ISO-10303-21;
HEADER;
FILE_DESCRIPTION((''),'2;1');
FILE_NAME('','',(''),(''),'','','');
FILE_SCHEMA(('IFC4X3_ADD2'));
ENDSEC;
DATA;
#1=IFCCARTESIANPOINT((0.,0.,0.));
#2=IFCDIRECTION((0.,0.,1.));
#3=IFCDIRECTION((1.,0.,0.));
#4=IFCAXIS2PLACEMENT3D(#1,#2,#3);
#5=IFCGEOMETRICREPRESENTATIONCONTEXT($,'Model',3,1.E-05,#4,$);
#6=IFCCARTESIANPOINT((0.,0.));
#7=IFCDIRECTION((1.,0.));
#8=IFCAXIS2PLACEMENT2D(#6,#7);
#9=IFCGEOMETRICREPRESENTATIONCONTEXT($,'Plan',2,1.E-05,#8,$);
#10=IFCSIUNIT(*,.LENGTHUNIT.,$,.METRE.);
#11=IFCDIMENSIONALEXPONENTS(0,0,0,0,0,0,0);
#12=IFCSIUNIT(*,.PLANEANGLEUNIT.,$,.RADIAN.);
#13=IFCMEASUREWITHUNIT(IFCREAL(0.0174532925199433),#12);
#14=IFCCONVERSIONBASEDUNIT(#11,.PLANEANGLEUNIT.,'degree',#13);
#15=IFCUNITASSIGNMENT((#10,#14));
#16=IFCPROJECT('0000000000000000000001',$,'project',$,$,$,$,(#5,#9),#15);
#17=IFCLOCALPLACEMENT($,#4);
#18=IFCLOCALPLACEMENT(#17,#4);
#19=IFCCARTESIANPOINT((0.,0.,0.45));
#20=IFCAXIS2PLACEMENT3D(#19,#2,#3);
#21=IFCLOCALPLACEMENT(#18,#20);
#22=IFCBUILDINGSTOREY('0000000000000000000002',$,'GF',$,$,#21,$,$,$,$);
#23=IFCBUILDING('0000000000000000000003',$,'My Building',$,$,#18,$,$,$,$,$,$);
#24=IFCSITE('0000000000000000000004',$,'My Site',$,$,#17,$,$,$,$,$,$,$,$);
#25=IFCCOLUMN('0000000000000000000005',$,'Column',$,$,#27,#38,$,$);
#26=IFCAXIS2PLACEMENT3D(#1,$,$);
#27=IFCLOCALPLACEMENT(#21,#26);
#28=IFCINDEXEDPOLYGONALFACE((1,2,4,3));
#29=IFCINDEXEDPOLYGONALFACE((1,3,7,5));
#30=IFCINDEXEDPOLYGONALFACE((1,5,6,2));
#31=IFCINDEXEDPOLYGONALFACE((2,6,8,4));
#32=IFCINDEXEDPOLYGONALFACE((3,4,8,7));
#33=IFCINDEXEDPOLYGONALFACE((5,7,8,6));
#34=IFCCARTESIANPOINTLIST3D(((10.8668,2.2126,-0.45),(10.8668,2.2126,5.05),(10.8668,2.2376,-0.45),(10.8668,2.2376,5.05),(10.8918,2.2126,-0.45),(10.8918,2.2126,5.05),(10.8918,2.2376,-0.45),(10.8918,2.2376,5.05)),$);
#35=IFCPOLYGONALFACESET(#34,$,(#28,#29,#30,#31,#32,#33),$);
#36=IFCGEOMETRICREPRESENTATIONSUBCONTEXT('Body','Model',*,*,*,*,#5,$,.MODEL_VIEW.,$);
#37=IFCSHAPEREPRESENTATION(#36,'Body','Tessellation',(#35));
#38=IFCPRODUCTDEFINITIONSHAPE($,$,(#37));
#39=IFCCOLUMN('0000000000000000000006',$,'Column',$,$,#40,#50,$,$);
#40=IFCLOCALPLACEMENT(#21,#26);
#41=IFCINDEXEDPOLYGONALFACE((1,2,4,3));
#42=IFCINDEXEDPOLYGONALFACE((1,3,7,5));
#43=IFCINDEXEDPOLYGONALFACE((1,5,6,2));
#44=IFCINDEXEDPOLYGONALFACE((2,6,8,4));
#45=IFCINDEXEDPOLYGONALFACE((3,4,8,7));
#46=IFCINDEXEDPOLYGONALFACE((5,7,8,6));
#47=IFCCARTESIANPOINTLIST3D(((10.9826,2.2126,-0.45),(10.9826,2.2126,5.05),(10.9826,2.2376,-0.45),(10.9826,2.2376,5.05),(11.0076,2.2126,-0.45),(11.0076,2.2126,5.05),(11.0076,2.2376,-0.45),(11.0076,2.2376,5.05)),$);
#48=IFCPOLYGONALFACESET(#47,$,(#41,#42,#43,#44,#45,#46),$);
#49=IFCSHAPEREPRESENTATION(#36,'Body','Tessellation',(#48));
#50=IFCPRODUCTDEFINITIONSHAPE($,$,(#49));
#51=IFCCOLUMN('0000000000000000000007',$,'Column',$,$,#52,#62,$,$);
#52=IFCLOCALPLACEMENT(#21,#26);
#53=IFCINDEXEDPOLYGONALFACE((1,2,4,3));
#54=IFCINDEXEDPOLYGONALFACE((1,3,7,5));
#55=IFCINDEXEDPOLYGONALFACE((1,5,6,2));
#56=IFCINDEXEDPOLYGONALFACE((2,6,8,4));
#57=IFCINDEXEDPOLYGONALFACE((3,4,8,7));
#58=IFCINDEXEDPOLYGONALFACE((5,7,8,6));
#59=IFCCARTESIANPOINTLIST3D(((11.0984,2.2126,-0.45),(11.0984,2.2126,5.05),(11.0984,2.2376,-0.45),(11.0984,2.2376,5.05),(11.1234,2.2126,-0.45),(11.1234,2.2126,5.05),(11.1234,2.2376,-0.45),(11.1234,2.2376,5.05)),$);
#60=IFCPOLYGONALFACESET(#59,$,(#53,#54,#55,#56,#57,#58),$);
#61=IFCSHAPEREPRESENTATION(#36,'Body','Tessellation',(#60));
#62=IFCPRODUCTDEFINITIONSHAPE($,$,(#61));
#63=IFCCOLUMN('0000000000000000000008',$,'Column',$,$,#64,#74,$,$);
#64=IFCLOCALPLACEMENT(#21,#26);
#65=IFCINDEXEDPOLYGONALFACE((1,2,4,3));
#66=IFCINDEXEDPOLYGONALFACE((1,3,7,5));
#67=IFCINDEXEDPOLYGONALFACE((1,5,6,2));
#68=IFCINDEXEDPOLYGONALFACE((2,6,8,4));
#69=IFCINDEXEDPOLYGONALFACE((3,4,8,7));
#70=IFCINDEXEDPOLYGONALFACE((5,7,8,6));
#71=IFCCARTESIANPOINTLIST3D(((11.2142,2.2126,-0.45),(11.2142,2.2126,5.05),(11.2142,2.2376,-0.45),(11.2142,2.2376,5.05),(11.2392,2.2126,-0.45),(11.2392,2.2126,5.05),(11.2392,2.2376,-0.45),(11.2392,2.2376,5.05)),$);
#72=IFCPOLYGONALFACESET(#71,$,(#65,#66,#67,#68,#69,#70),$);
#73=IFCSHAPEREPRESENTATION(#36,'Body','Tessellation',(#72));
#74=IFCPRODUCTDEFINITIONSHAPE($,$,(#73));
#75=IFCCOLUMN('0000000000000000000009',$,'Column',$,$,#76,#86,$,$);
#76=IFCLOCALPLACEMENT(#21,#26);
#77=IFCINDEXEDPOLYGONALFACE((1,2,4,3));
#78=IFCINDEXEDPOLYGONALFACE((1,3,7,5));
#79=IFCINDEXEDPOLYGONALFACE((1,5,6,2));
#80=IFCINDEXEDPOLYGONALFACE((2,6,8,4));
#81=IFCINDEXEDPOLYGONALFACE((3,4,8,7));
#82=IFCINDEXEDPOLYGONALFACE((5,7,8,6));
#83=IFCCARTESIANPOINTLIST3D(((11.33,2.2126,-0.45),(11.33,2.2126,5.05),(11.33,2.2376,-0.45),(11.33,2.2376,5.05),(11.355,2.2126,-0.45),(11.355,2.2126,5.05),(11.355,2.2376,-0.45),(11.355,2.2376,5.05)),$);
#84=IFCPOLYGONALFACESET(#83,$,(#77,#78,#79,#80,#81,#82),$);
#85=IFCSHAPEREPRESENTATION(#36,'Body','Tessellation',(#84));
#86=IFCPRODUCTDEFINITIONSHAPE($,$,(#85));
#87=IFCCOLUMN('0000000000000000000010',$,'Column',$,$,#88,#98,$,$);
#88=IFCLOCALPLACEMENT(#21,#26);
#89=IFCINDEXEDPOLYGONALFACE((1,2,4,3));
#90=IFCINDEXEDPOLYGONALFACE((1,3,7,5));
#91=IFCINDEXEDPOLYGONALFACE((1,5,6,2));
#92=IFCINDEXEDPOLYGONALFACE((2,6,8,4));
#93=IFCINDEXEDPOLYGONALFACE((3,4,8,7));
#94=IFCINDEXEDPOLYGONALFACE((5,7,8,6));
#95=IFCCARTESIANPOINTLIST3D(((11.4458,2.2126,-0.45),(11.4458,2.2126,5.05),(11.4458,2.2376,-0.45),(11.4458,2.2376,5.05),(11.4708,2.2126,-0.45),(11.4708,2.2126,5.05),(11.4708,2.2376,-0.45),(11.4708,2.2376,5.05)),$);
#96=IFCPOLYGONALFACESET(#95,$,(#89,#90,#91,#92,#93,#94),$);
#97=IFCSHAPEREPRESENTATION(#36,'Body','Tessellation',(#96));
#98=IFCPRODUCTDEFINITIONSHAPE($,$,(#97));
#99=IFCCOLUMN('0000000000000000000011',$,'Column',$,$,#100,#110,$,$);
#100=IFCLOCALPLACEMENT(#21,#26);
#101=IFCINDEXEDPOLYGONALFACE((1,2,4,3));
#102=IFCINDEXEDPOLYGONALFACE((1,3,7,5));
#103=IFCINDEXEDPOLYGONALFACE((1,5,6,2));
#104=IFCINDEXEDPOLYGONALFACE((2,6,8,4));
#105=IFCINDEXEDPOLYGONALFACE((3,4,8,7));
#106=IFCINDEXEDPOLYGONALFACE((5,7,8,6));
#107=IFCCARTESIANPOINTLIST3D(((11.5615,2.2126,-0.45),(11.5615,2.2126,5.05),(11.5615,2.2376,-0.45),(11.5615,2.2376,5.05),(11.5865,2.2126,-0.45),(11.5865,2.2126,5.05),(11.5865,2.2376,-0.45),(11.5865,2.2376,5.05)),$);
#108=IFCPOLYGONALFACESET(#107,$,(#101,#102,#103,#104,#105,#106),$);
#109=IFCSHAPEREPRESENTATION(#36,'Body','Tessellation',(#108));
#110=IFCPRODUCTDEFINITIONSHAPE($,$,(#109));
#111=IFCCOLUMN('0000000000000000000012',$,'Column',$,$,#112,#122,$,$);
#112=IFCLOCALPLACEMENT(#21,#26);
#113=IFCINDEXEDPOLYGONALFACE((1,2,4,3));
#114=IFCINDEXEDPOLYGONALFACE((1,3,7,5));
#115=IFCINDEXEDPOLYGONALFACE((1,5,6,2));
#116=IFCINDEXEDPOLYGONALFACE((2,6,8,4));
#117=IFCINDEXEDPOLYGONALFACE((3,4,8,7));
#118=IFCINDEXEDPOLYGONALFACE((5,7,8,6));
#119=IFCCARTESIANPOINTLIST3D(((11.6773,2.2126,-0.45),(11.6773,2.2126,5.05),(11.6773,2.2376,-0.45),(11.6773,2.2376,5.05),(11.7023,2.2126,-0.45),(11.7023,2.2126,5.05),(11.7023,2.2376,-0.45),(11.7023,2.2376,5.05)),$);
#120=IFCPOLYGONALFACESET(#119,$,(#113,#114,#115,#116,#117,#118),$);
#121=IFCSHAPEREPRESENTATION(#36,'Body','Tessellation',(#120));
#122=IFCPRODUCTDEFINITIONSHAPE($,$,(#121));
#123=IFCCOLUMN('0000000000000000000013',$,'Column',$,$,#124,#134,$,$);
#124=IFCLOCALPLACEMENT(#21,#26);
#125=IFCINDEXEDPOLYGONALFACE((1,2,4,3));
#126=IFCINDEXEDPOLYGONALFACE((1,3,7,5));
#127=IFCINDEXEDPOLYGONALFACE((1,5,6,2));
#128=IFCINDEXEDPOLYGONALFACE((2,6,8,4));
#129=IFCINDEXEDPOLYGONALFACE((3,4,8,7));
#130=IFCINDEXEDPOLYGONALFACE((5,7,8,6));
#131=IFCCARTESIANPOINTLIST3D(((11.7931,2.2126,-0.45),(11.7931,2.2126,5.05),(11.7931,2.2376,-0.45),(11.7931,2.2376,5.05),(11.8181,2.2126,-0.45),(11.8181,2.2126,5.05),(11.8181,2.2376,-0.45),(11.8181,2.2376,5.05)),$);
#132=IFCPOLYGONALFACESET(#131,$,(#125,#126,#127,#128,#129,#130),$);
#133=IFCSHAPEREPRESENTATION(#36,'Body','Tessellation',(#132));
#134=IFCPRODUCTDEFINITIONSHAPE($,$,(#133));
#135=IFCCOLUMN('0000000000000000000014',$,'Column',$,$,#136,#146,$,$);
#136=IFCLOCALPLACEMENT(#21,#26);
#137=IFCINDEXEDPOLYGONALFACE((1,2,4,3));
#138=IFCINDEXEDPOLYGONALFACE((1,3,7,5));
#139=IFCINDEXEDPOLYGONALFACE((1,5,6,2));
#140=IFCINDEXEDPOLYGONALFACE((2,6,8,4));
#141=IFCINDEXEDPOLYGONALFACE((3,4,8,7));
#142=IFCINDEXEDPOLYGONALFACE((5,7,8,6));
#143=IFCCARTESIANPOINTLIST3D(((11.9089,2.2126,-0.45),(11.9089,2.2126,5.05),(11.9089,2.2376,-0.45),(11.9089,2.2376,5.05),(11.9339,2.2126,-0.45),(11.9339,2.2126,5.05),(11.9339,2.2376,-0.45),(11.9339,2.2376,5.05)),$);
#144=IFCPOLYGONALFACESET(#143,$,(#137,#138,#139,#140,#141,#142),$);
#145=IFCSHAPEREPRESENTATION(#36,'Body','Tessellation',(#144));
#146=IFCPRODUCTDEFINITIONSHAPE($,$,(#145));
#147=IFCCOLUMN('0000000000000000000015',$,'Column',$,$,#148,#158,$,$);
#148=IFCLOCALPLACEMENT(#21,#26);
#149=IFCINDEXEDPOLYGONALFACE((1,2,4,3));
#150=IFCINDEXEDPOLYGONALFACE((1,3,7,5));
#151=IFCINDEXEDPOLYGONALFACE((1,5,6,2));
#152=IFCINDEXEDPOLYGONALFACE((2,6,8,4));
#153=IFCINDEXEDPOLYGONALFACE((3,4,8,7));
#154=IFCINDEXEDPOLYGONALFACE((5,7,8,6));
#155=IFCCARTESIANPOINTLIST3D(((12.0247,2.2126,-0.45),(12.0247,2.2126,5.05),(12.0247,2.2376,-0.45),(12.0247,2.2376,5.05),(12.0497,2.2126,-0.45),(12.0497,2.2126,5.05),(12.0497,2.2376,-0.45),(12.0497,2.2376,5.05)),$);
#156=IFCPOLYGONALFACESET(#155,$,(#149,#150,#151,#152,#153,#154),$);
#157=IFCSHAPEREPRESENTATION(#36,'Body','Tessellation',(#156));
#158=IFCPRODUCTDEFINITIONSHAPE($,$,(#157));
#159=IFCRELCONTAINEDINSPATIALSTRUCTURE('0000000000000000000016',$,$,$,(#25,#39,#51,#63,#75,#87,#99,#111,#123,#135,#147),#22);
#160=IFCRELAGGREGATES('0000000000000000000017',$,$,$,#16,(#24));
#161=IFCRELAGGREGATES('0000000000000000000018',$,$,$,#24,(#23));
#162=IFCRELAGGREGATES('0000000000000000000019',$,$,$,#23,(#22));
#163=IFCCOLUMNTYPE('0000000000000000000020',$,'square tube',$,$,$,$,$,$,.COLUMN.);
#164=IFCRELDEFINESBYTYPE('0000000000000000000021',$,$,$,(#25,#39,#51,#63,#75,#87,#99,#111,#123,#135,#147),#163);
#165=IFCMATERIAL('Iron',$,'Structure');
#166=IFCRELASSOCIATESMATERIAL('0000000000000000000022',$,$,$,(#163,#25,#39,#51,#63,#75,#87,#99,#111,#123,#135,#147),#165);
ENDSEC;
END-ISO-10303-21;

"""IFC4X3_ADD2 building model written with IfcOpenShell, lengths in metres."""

from ifc_helpers import new_model, entity, si_unit, converted_unit, frame, origin_with_axes, origin_2d_with_axis, place, context, subcontext, project, spatial, indexed_curve, outline, extrude, material, material_profile, profile_set, profile_usage, type_object, element, save


model = new_model("IFC4X3_ADD2")

# Units and contexts
model_context = context("Model", 3, precision=1e-05, world=origin_with_axes())
plan_context = context("Plan", 2, precision=1e-05, world=origin_2d_with_axis())
body_context_1 = subcontext(model_context, "Body", "Model", "MODEL_VIEW")
ifc_project = project(units=[si_unit("LENGTHUNIT", "METRE"), converted_unit("PLANEANGLEUNIT", "degree", entity("IfcReal", 0.0174532925199433), si_unit("PLANEANGLEUNIT", "RADIAN"), dimensions=[0, 0, 0, 0, 0, 0, 0])], contexts=[model_context, plan_context])

# Site, building, storey
site_placement = place(None, origin_with_axes())
site = spatial("IfcSite", under=ifc_project, at=site_placement, Name="My Site")
building_placement = place(site_placement, origin_with_axes())
building = spatial("IfcBuilding", under=site, at=building_placement, Name="My Building")
storey_placement = place(building_placement, frame((0.0, 0.0, 0.45), z_axis=(0.0, 0.0, 1.0), x_axis=(1.0, 0.0, 0.0)))
storey = spatial("IfcBuildingStorey", under=building, at=storey_placement, Name="GF")

# Columns
ifc_material_1 = material(Name="Iron", Category="Structure")
ifc_material_profile = material_profile(ifc_material_1, outline(indexed_curve([(-0.0125, -0.0125), (0.0125, -0.0125), (0.0125, 0.0125), (-0.0125, 0.0125), (-0.0125, -0.0125)])))
ifc_profile_set = profile_set([ifc_material_profile])
column_type = type_object("IfcColumnType", Name="square tube", PredefinedType="COLUMN", material=ifc_profile_set)
ifc_profile_usage_1 = profile_usage(ifc_profile_set, cardinal=5)
column_1_placement = place(storey_placement, frame((10.8793, 2.2251, -0.45), z_axis=(0.0, 0.0, 1.0), x_axis=(1.0, 0.0, 0.0)))
element("IfcColumn", 1, at=column_1_placement, inside=storey, type_object=column_type, material=ifc_profile_usage_1, Name="Column", context=body_context_1, shape_type="SweptSolid", body=[
    extrude(outline(indexed_curve([(-0.0125, -0.0125), (0.0125, -0.0125), (0.0125, 0.0125), (-0.0125, 0.0125), (-0.0125, -0.0125)])), origin_with_axes(), (0.0, 0.0, 1.0), 5.5),
])
ifc_profile_usage_2 = profile_usage(ifc_profile_set, cardinal=5)
column_2_placement = place(storey_placement, frame((10.9951, 2.2251, -0.45), z_axis=(0.0, 0.0, 1.0), x_axis=(1.0, 0.0, 0.0)))
element("IfcColumn", 2, at=column_2_placement, inside=storey, type_object=column_type, material=ifc_profile_usage_2, Name="Column", context=body_context_1, shape_type="SweptSolid", body=[
    extrude(outline(indexed_curve([(-0.0125, -0.0125), (0.0125, -0.0125), (0.0125, 0.0125), (-0.0125, 0.0125), (-0.0125, -0.0125)])), origin_with_axes(), (0.0, 0.0, 1.0), 5.5),
])
ifc_profile_usage_3 = profile_usage(ifc_profile_set, cardinal=5)
column_3_placement = place(storey_placement, frame((11.1109, 2.2251, -0.45), z_axis=(0.0, 0.0, 1.0), x_axis=(1.0, 0.0, 0.0)))
element("IfcColumn", 3, at=column_3_placement, inside=storey, type_object=column_type, material=ifc_profile_usage_3, Name="Column", context=body_context_1, shape_type="SweptSolid", body=[
    extrude(outline(indexed_curve([(-0.0125, -0.0125), (0.0125, -0.0125), (0.0125, 0.0125), (-0.0125, 0.0125), (-0.0125, -0.0125)])), origin_with_axes(), (0.0, 0.0, 1.0), 5.5),
])
ifc_profile_usage_4 = profile_usage(ifc_profile_set, cardinal=5)
column_4_placement = place(storey_placement, frame((11.2267, 2.2251, -0.45), z_axis=(0.0, 0.0, 1.0), x_axis=(1.0, 0.0, 0.0)))
element("IfcColumn", 4, at=column_4_placement, inside=storey, type_object=column_type, material=ifc_profile_usage_4, Name="Column", context=body_context_1, shape_type="SweptSolid", body=[
    extrude(outline(indexed_curve([(-0.0125, -0.0125), (0.0125, -0.0125), (0.0125, 0.0125), (-0.0125, 0.0125), (-0.0125, -0.0125)])), origin_with_axes(), (0.0, 0.0, 1.0), 5.5),
])
ifc_profile_usage_5 = profile_usage(ifc_profile_set, cardinal=5)
column_5_placement = place(storey_placement, frame((11.3425, 2.2251, -0.45), z_axis=(0.0, 0.0, 1.0), x_axis=(1.0, 0.0, 0.0)))
element("IfcColumn", 5, at=column_5_placement, inside=storey, type_object=column_type, material=ifc_profile_usage_5, Name="Column", context=body_context_1, shape_type="SweptSolid", body=[
    extrude(outline(indexed_curve([(-0.0125, -0.0125), (0.0125, -0.0125), (0.0125, 0.0125), (-0.0125, 0.0125), (-0.0125, -0.0125)])), origin_with_axes(), (0.0, 0.0, 1.0), 5.5),
])
ifc_profile_usage_6 = profile_usage(ifc_profile_set, cardinal=5)
column_6_placement = place(storey_placement, frame((11.4583, 2.2251, -0.45), z_axis=(0.0, 0.0, 1.0), x_axis=(1.0, 0.0, 0.0)))
element("IfcColumn", 6, at=column_6_placement, inside=storey, type_object=column_type, material=ifc_profile_usage_6, Name="Column", context=body_context_1, shape_type="SweptSolid", body=[
    extrude(outline(indexed_curve([(-0.0125, -0.0125), (0.0125, -0.0125), (0.0125, 0.0125), (-0.0125, 0.0125), (-0.0125, -0.0125)])), origin_with_axes(), (0.0, 0.0, 1.0), 5.5),
])
ifc_profile_usage_7 = profile_usage(ifc_profile_set, cardinal=5)
column_7_placement = place(storey_placement, frame((11.574, 2.2251, -0.45), z_axis=(0.0, 0.0, 1.0), x_axis=(1.0, 0.0, 0.0)))
element("IfcColumn", 7, at=column_7_placement, inside=storey, type_object=column_type, material=ifc_profile_usage_7, Name="Column", context=body_context_1, shape_type="SweptSolid", body=[
    extrude(outline(indexed_curve([(-0.0125, -0.0125), (0.0125, -0.0125), (0.0125, 0.0125), (-0.0125, 0.0125), (-0.0125, -0.0125)])), origin_with_axes(), (0.0, 0.0, 1.0), 5.5),
])
ifc_profile_usage_8 = profile_usage(ifc_profile_set, cardinal=5)
column_8_placement = place(storey_placement, frame((11.6898, 2.2251, -0.45), z_axis=(0.0, 0.0, 1.0), x_axis=(1.0, 0.0, 0.0)))
element("IfcColumn", 8, at=column_8_placement, inside=storey, type_object=column_type, material=ifc_profile_usage_8, Name="Column", context=body_context_1, shape_type="SweptSolid", body=[
    extrude(outline(indexed_curve([(-0.0125, -0.0125), (0.0125, -0.0125), (0.0125, 0.0125), (-0.0125, 0.0125), (-0.0125, -0.0125)])), origin_with_axes(), (0.0, 0.0, 1.0), 5.5),
])
ifc_profile_usage_9 = profile_usage(ifc_profile_set, cardinal=5)
column_9_placement = place(storey_placement, frame((11.8056, 2.2251, -0.45), z_axis=(0.0, 0.0, 1.0), x_axis=(1.0, 0.0, 0.0)))
element("IfcColumn", 9, at=column_9_placement, inside=storey, type_object=column_type, material=ifc_profile_usage_9, Name="Column", context=body_context_1, shape_type="SweptSolid", body=[
    extrude(outline(indexed_curve([(-0.0125, -0.0125), (0.0125, -0.0125), (0.0125, 0.0125), (-0.0125, 0.0125), (-0.0125, -0.0125)])), origin_with_axes(), (0.0, 0.0, 1.0), 5.5),
])
ifc_profile_usage_10 = profile_usage(ifc_profile_set, cardinal=5)
column_10_placement = place(storey_placement, frame((11.9214, 2.2251, -0.45), z_axis=(0.0, 0.0, 1.0), x_axis=(1.0, 0.0, 0.0)))
element("IfcColumn", 10, at=column_10_placement, inside=storey, type_object=column_type, material=ifc_profile_usage_10, Name="Column", context=body_context_1, shape_type="SweptSolid", body=[
    extrude(outline(indexed_curve([(-0.0125, -0.0125), (0.0125, -0.0125), (0.0125, 0.0125), (-0.0125, 0.0125), (-0.0125, -0.0125)])), origin_with_axes(), (0.0, 0.0, 1.0), 5.5),
])
ifc_profile_usage_11 = profile_usage(ifc_profile_set, cardinal=5)
column_11_placement = place(storey_placement, frame((12.0372, 2.2251, -0.45), z_axis=(0.0, 0.0, 1.0), x_axis=(1.0, 0.0, 0.0)))
element("IfcColumn", 11, at=column_11_placement, inside=storey, type_object=column_type, material=ifc_profile_usage_11, Name="Column", context=body_context_1, shape_type="SweptSolid", body=[
    extrude(outline(indexed_curve([(-0.0125, -0.0125), (0.0125, -0.0125), (0.0125, 0.0125), (-0.0125, 0.0125), (-0.0125, -0.0125)])), origin_with_axes(), (0.0, 0.0, 1.0), 5.5),
])

save(model, "model.ifc")
